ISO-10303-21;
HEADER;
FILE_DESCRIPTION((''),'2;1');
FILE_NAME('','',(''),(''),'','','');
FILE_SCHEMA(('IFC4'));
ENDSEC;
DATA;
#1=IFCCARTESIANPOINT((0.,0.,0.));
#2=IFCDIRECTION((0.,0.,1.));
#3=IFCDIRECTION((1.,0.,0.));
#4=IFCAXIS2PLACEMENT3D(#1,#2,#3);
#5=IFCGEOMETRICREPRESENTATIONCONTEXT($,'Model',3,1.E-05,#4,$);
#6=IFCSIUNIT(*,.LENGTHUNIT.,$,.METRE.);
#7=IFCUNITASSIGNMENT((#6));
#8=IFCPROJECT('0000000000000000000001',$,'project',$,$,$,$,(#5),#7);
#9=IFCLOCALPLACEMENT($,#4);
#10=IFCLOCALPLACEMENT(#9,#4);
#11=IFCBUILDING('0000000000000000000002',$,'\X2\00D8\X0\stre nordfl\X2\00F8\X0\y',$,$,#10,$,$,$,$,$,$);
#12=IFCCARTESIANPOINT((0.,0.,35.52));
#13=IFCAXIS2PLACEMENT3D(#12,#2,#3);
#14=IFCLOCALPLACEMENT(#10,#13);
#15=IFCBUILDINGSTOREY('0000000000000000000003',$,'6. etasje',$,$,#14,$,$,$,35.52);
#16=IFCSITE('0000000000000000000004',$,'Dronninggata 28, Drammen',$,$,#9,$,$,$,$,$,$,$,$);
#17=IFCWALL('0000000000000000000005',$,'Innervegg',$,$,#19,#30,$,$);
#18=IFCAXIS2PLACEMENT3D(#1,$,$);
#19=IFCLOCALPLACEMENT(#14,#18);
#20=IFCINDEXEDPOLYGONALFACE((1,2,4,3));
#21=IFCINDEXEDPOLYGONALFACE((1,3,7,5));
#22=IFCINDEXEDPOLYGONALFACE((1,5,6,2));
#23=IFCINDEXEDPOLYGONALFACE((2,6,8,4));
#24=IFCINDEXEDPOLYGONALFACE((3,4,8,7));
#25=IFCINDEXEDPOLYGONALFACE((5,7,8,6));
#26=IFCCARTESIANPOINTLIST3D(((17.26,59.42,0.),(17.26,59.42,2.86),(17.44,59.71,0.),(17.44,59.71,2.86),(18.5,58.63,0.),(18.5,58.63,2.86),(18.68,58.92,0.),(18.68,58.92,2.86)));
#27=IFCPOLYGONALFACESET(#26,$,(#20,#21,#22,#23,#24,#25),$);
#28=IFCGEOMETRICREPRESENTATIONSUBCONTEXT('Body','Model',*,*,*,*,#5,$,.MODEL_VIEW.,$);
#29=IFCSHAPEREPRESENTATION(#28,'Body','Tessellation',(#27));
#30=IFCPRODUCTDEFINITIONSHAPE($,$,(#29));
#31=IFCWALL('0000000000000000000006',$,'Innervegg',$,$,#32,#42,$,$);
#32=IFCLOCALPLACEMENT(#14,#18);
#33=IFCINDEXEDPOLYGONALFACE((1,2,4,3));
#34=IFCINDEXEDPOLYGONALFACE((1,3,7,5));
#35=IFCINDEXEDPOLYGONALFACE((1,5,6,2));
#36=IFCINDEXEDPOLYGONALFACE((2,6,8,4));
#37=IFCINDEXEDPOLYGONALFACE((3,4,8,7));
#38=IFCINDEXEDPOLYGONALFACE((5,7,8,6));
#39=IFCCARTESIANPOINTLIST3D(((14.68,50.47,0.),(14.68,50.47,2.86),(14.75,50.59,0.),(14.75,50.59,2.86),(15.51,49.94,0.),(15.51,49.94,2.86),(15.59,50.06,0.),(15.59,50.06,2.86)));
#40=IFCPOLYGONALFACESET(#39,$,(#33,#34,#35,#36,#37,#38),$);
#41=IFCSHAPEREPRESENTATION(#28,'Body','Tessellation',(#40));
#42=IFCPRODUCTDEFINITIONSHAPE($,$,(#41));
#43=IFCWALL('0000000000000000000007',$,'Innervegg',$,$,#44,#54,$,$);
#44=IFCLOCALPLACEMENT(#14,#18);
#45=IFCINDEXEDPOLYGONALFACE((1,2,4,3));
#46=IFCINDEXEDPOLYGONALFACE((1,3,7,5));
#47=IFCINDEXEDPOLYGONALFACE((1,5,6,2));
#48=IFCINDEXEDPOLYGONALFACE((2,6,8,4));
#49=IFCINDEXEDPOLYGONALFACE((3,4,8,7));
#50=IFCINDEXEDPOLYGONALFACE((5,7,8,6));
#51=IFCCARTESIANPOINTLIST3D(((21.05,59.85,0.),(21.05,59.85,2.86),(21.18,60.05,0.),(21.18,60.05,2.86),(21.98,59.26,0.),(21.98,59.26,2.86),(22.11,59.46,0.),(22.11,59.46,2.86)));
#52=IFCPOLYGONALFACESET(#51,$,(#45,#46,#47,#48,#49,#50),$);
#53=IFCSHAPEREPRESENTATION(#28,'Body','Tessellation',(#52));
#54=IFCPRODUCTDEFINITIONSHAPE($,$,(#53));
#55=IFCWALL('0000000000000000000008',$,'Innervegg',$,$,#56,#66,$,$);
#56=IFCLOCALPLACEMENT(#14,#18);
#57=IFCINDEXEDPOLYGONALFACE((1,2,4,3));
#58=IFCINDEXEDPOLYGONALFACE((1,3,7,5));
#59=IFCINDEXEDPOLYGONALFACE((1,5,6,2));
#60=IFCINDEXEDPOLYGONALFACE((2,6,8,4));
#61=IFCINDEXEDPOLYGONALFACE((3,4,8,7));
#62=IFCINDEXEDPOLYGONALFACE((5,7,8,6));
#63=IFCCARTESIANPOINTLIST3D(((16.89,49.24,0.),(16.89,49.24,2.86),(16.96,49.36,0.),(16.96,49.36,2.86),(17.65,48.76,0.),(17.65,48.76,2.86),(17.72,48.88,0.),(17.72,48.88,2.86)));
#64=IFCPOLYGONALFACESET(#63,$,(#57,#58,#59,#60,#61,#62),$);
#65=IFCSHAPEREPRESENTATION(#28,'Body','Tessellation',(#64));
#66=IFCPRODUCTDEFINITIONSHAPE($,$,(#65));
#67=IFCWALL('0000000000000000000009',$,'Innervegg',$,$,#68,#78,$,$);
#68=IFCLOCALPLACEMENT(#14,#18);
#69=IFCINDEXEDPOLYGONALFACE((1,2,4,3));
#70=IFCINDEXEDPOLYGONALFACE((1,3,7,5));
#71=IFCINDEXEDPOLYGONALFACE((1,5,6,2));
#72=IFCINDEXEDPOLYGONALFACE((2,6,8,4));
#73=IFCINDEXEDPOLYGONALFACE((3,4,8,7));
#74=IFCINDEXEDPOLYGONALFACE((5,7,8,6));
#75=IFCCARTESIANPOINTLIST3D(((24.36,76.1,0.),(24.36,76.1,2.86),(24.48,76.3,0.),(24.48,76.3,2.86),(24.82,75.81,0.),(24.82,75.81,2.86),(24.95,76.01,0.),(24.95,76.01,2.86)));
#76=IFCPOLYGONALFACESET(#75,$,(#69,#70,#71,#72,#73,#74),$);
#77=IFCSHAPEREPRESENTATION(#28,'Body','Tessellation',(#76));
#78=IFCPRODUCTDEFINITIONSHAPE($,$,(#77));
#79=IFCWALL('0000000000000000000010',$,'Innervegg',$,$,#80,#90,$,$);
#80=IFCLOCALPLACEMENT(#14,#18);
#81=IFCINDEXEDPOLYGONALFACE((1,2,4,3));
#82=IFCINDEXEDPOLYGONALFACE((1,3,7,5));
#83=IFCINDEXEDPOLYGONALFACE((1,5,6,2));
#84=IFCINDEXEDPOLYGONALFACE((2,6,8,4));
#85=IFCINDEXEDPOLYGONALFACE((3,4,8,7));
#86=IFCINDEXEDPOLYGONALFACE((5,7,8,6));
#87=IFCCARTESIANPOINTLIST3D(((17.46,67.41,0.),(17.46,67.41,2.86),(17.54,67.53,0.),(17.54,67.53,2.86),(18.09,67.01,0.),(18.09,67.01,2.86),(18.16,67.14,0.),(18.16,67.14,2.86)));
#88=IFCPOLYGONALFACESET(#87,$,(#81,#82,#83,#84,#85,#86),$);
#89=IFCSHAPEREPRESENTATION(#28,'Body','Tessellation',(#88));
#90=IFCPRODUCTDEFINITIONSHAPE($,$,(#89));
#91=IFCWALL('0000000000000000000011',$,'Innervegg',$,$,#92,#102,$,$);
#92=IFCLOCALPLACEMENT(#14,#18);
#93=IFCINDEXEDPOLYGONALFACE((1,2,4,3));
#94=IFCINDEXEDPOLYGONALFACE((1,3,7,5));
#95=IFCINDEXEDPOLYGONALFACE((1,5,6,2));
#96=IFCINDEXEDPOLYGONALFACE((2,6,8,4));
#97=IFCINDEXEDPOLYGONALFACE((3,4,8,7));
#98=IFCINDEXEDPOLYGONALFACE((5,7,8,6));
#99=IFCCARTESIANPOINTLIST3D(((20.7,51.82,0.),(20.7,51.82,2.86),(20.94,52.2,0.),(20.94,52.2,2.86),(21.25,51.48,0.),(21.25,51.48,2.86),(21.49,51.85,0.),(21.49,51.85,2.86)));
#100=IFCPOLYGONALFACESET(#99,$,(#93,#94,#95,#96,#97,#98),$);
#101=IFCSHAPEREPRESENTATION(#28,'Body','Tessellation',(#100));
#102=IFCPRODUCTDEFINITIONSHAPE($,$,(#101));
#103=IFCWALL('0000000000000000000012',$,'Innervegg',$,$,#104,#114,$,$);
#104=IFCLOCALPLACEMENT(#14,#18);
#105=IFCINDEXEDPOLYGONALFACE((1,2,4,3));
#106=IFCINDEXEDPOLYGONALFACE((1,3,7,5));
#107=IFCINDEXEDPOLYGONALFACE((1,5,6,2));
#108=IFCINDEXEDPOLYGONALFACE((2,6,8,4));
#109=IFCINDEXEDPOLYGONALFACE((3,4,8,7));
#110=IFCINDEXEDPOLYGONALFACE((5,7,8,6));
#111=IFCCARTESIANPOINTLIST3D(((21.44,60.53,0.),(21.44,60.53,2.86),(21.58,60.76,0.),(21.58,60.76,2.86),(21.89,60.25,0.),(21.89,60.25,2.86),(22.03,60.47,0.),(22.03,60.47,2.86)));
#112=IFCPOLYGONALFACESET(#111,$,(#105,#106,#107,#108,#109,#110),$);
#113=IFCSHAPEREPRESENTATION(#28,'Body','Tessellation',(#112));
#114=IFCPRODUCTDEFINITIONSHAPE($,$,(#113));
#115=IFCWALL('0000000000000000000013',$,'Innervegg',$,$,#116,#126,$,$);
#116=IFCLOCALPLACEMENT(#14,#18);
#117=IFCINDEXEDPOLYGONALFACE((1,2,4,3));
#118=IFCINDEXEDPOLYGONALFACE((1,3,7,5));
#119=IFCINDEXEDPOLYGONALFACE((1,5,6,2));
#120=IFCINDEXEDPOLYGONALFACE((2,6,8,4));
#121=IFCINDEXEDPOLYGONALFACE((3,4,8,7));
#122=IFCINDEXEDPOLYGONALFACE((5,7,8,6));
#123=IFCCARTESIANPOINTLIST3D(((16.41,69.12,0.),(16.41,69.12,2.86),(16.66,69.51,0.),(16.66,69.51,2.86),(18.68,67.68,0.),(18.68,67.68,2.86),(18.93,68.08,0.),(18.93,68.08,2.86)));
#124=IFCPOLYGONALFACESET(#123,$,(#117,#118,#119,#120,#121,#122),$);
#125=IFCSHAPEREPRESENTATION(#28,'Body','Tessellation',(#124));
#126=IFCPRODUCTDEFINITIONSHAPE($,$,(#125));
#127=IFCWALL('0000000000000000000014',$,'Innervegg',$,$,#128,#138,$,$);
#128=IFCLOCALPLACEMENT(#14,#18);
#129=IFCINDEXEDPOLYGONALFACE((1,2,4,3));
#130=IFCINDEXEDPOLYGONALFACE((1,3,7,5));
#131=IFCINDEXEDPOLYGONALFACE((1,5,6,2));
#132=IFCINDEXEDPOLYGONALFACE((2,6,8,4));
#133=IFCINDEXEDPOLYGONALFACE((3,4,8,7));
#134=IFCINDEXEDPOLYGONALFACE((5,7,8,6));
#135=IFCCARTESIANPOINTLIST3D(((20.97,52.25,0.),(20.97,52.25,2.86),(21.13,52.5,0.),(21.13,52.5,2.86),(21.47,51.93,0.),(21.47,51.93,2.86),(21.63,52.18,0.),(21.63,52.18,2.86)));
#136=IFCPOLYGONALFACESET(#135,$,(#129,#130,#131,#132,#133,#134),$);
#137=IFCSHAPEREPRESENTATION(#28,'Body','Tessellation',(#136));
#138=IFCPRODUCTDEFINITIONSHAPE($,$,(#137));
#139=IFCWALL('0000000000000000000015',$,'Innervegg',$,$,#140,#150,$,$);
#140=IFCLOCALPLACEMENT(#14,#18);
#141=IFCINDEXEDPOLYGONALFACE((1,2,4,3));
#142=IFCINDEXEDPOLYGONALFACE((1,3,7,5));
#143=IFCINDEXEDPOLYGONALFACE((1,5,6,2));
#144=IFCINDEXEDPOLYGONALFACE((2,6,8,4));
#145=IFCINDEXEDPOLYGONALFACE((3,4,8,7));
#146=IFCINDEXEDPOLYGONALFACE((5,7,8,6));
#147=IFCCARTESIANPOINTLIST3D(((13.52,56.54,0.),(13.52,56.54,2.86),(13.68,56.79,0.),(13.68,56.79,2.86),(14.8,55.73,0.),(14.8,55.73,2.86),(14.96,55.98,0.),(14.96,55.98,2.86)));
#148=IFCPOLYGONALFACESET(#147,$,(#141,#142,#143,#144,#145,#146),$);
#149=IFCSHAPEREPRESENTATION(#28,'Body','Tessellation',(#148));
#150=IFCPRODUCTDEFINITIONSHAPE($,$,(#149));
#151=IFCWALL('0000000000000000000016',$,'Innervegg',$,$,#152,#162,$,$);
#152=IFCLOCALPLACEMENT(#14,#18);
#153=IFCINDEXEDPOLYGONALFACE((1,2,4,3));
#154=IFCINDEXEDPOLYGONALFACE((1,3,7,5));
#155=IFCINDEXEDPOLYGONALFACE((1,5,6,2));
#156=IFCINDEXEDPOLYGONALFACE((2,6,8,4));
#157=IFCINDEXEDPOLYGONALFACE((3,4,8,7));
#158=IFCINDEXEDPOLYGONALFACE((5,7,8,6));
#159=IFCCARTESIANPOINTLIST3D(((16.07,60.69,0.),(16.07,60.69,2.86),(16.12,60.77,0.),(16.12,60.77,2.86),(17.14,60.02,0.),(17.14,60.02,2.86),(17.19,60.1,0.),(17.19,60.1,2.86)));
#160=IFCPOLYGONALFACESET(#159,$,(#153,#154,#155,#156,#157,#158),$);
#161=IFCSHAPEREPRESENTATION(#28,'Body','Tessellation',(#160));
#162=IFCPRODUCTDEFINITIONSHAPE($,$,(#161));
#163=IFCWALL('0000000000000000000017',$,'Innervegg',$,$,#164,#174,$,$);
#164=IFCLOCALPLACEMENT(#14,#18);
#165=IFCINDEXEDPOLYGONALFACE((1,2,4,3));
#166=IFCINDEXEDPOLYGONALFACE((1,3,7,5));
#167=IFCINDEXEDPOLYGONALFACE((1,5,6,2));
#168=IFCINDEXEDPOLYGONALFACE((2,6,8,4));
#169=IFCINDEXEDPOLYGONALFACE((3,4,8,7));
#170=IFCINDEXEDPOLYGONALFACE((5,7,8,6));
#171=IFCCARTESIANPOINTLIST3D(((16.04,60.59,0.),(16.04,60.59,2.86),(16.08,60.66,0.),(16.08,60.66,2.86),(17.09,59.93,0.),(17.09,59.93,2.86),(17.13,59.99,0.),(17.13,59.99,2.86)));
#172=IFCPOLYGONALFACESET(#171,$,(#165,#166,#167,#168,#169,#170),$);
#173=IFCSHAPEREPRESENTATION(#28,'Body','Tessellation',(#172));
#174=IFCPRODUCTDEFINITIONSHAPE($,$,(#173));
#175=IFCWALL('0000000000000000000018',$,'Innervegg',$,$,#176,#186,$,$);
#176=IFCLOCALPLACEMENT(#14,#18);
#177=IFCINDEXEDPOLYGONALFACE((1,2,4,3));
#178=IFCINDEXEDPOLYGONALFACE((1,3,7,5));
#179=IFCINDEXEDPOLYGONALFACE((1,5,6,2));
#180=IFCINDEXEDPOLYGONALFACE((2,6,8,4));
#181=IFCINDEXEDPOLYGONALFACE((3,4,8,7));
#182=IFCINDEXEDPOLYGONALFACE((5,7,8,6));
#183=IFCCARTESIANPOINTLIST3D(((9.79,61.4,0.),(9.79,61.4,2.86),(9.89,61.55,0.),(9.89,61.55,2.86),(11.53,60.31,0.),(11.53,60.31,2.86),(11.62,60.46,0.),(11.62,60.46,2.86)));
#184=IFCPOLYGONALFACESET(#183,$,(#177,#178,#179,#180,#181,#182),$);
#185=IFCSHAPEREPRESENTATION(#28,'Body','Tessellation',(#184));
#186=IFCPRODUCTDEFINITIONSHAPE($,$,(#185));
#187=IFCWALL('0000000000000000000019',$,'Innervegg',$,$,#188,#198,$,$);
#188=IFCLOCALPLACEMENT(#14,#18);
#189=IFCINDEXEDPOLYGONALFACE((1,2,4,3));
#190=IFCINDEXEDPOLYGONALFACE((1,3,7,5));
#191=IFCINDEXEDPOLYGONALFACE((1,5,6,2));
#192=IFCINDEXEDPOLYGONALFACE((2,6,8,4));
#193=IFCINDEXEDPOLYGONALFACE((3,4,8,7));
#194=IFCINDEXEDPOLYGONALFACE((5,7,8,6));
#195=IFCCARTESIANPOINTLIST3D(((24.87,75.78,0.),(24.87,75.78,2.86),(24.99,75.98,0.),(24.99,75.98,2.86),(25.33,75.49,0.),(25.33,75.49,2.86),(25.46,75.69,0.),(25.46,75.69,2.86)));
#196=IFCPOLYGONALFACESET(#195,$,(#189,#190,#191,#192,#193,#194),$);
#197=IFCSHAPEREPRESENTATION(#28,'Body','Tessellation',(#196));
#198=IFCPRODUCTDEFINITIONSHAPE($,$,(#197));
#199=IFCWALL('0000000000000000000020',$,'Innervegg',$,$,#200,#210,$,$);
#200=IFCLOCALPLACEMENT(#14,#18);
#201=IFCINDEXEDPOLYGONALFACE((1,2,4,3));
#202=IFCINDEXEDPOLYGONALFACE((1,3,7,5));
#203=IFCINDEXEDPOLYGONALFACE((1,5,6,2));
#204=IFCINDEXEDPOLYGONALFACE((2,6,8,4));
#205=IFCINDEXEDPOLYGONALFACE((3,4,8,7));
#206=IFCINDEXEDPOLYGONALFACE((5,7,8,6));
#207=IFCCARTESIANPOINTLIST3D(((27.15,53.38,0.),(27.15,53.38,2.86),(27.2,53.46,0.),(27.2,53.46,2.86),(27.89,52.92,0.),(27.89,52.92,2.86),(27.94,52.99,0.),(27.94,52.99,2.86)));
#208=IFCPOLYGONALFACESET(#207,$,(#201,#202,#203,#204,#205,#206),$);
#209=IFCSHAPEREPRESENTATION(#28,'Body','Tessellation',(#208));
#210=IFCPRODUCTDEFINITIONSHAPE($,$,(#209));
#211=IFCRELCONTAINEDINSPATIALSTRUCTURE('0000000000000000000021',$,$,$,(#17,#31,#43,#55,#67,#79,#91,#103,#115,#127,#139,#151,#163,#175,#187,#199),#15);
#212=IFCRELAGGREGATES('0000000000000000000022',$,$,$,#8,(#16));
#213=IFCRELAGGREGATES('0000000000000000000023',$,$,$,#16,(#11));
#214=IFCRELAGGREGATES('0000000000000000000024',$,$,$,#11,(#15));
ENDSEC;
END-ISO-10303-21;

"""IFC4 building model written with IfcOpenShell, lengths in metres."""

from ifc_helpers import new_model, si_unit, frame, origin_with_axes, place, context, subcontext, project, spatial, polyline, outline, extrude, element, save


model = new_model("IFC4")

# Units and contexts
model_context = context("Model", 3, precision=1e-05, world=origin_with_axes())
body_context = subcontext(model_context, "Body", "Model", "MODEL_VIEW")
ifc_project = project(units=[si_unit("LENGTHUNIT", "METRE")], contexts=[model_context])

# Site, building, storey
site_placement = place(None, origin_with_axes())
site = spatial("IfcSite", under=ifc_project, at=site_placement, Name="Dronninggata 28, Drammen")
building_placement = place(site_placement, origin_with_axes())
building = spatial("IfcBuilding", under=site, at=building_placement, Name="Østre nordfløy")
storey_placement = place(building_placement, frame((0.0, 0.0, 35.52), z_axis=(0.0, 0.0, 1.0), x_axis=(1.0, 0.0, 0.0)))
storey = spatial("IfcBuildingStorey", under=building, at=storey_placement, Name="6. etasje", Elevation=35.52)

# Walls
wall_1_placement = place(storey_placement, frame((0.0, 0.0, -35.52), z_axis=(0.0, 0.0, 1.0), x_axis=(1.0, 0.0, 0.0)))
element("IfcWall", 1, at=wall_1_placement, inside=storey, Name="Innervegg", context=body_context, shape_type="SweptSolid", body=[
    extrude(outline(polyline([(18.68, 58.92), (18.5, 58.63), (17.26, 59.42), (17.44, 59.71), (18.68, 58.92)])), frame((0.0, 0.0, 35.52)), (0.0, 0.0, 1.0), 2.86),
])
wall_2_placement = place(storey_placement, frame((0.0, 0.0, -35.52), z_axis=(0.0, 0.0, 1.0), x_axis=(1.0, 0.0, 0.0)))
element("IfcWall", 2, at=wall_2_placement, inside=storey, Name="Innervegg", context=body_context, shape_type="SweptSolid", body=[
    extrude(outline(polyline([(15.59, 50.06), (15.51, 49.94), (14.68, 50.47), (14.75, 50.59), (15.59, 50.06)])), frame((0.0, 0.0, 35.52)), (0.0, 0.0, 1.0), 2.86),
])
wall_3_placement = place(storey_placement, frame((0.0, 0.0, -35.52), z_axis=(0.0, 0.0, 1.0), x_axis=(1.0, 0.0, 0.0)))
element("IfcWall", 3, at=wall_3_placement, inside=storey, Name="Innervegg", context=body_context, shape_type="SweptSolid", body=[
    extrude(outline(polyline([(22.11, 59.46), (21.98, 59.26), (21.05, 59.85), (21.18, 60.05), (22.11, 59.46)])), frame((0.0, 0.0, 35.52)), (0.0, 0.0, 1.0), 2.86),
])
wall_4_placement = place(storey_placement, frame((0.0, 0.0, -35.52), z_axis=(0.0, 0.0, 1.0), x_axis=(1.0, 0.0, 0.0)))
element("IfcWall", 4, at=wall_4_placement, inside=storey, Name="Innervegg", context=body_context, shape_type="SweptSolid", body=[
    extrude(outline(polyline([(17.72, 48.88), (17.65, 48.76), (16.89, 49.24), (16.96, 49.36), (17.72, 48.88)])), frame((0.0, 0.0, 35.52)), (0.0, 0.0, 1.0), 2.86),
])
wall_5_placement = place(storey_placement, frame((0.0, 0.0, -35.52), z_axis=(0.0, 0.0, 1.0), x_axis=(1.0, 0.0, 0.0)))
element("IfcWall", 5, at=wall_5_placement, inside=storey, Name="Innervegg", context=body_context, shape_type="SweptSolid", body=[
    extrude(outline(polyline([(24.95, 76.01), (24.82, 75.81), (24.36, 76.1), (24.48, 76.3), (24.95, 76.01)])), frame((0.0, 0.0, 35.52)), (0.0, 0.0, 1.0), 2.86),
])
wall_6_placement = place(storey_placement, frame((0.0, 0.0, -35.52), z_axis=(0.0, 0.0, 1.0), x_axis=(1.0, 0.0, 0.0)))
element("IfcWall", 6, at=wall_6_placement, inside=storey, Name="Innervegg", context=body_context, shape_type="SweptSolid", body=[
    extrude(outline(polyline([(18.16, 67.14), (18.09, 67.01), (17.46, 67.41), (17.54, 67.53), (18.16, 67.14)])), frame((0.0, 0.0, 35.52)), (0.0, 0.0, 1.0), 2.86),
])
wall_7_placement = place(storey_placement, frame((0.0, 0.0, -35.52), z_axis=(0.0, 0.0, 1.0), x_axis=(1.0, 0.0, 0.0)))
element("IfcWall", 7, at=wall_7_placement, inside=storey, Name="Innervegg", context=body_context, shape_type="SweptSolid", body=[
    extrude(outline(polyline([(21.49, 51.85), (21.25, 51.48), (20.7, 51.82), (20.94, 52.2), (21.49, 51.85)])), frame((0.0, 0.0, 35.52)), (0.0, 0.0, 1.0), 2.86),
])
wall_8_placement = place(storey_placement, frame((0.0, 0.0, -35.52), z_axis=(0.0, 0.0, 1.0), x_axis=(1.0, 0.0, 0.0)))
element("IfcWall", 8, at=wall_8_placement, inside=storey, Name="Innervegg", context=body_context, shape_type="SweptSolid", body=[
    extrude(outline(polyline([(22.03, 60.47), (21.89, 60.25), (21.44, 60.53), (21.58, 60.76), (22.03, 60.47)])), frame((0.0, 0.0, 35.52)), (0.0, 0.0, 1.0), 2.86),
])
wall_9_placement = place(storey_placement, frame((0.0, 0.0, -35.52), z_axis=(0.0, 0.0, 1.0), x_axis=(1.0, 0.0, 0.0)))
element("IfcWall", 9, at=wall_9_placement, inside=storey, Name="Innervegg", context=body_context, shape_type="SweptSolid", body=[
    extrude(outline(polyline([(18.93, 68.08), (18.68, 67.68), (16.41, 69.12), (16.66, 69.51), (18.93, 68.08)])), frame((0.0, 0.0, 35.52)), (0.0, 0.0, 1.0), 2.86),
])
wall_10_placement = place(storey_placement, frame((0.0, 0.0, -35.52), z_axis=(0.0, 0.0, 1.0), x_axis=(1.0, 0.0, 0.0)))
element("IfcWall", 10, at=wall_10_placement, inside=storey, Name="Innervegg", context=body_context, shape_type="SweptSolid", body=[
    extrude(outline(polyline([(21.63, 52.18), (21.47, 51.93), (20.97, 52.25), (21.13, 52.5), (21.63, 52.18)])), frame((0.0, 0.0, 35.52)), (0.0, 0.0, 1.0), 2.86),
])
wall_11_placement = place(storey_placement, frame((0.0, 0.0, -35.52), z_axis=(0.0, 0.0, 1.0), x_axis=(1.0, 0.0, 0.0)))
element("IfcWall", 11, at=wall_11_placement, inside=storey, Name="Innervegg", context=body_context, shape_type="SweptSolid", body=[
    extrude(outline(polyline([(14.96, 55.98), (14.8, 55.73), (13.52, 56.54), (13.68, 56.79), (14.96, 55.98)])), frame((0.0, 0.0, 35.52)), (0.0, 0.0, 1.0), 2.86),
])
wall_12_placement = place(storey_placement, frame((0.0, 0.0, -35.52), z_axis=(0.0, 0.0, 1.0), x_axis=(1.0, 0.0, 0.0)))
element("IfcWall", 12, at=wall_12_placement, inside=storey, Name="Innervegg", context=body_context, shape_type="SweptSolid", body=[
    extrude(outline(polyline([(17.19, 60.1), (17.14, 60.02), (16.07, 60.69), (16.12, 60.77), (17.19, 60.1)])), frame((0.0, 0.0, 35.52)), (0.0, 0.0, 1.0), 2.86),
])
wall_13_placement = place(storey_placement, frame((0.0, 0.0, -35.52), z_axis=(0.0, 0.0, 1.0), x_axis=(1.0, 0.0, 0.0)))
element("IfcWall", 13, at=wall_13_placement, inside=storey, Name="Innervegg", context=body_context, shape_type="SweptSolid", body=[
    extrude(outline(polyline([(17.13, 59.99), (17.09, 59.93), (16.04, 60.59), (16.08, 60.66), (17.13, 59.99)])), frame((0.0, 0.0, 35.52)), (0.0, 0.0, 1.0), 2.86),
])
wall_14_placement = place(storey_placement, frame((0.0, 0.0, -35.52), z_axis=(0.0, 0.0, 1.0), x_axis=(1.0, 0.0, 0.0)))
element("IfcWall", 14, at=wall_14_placement, inside=storey, Name="Innervegg", context=body_context, shape_type="SweptSolid", body=[
    extrude(outline(polyline([(11.62, 60.46), (11.53, 60.31), (9.79, 61.4), (9.89, 61.55), (11.62, 60.46)])), frame((0.0, 0.0, 35.52)), (0.0, 0.0, 1.0), 2.86),
])
wall_15_placement = place(storey_placement, frame((0.0, 0.0, -35.52), z_axis=(0.0, 0.0, 1.0), x_axis=(1.0, 0.0, 0.0)))
element("IfcWall", 15, at=wall_15_placement, inside=storey, Name="Innervegg", context=body_context, shape_type="SweptSolid", body=[
    extrude(outline(polyline([(25.46, 75.69), (25.33, 75.49), (24.87, 75.78), (24.99, 75.98), (25.46, 75.69)])), frame((0.0, 0.0, 35.52)), (0.0, 0.0, 1.0), 2.86),
])
wall_16_placement = place(storey_placement, frame((0.0, 0.0, -35.52), z_axis=(0.0, 0.0, 1.0), x_axis=(1.0, 0.0, 0.0)))
element("IfcWall", 16, at=wall_16_placement, inside=storey, Name="Innervegg", context=body_context, shape_type="SweptSolid", body=[
    extrude(outline(polyline([(27.94, 52.99), (27.89, 52.92), (27.15, 53.38), (27.2, 53.46), (27.94, 52.99)])), frame((0.0, 0.0, 35.52)), (0.0, 0.0, 1.0), 2.86),
])

save(model, "model.ifc")
